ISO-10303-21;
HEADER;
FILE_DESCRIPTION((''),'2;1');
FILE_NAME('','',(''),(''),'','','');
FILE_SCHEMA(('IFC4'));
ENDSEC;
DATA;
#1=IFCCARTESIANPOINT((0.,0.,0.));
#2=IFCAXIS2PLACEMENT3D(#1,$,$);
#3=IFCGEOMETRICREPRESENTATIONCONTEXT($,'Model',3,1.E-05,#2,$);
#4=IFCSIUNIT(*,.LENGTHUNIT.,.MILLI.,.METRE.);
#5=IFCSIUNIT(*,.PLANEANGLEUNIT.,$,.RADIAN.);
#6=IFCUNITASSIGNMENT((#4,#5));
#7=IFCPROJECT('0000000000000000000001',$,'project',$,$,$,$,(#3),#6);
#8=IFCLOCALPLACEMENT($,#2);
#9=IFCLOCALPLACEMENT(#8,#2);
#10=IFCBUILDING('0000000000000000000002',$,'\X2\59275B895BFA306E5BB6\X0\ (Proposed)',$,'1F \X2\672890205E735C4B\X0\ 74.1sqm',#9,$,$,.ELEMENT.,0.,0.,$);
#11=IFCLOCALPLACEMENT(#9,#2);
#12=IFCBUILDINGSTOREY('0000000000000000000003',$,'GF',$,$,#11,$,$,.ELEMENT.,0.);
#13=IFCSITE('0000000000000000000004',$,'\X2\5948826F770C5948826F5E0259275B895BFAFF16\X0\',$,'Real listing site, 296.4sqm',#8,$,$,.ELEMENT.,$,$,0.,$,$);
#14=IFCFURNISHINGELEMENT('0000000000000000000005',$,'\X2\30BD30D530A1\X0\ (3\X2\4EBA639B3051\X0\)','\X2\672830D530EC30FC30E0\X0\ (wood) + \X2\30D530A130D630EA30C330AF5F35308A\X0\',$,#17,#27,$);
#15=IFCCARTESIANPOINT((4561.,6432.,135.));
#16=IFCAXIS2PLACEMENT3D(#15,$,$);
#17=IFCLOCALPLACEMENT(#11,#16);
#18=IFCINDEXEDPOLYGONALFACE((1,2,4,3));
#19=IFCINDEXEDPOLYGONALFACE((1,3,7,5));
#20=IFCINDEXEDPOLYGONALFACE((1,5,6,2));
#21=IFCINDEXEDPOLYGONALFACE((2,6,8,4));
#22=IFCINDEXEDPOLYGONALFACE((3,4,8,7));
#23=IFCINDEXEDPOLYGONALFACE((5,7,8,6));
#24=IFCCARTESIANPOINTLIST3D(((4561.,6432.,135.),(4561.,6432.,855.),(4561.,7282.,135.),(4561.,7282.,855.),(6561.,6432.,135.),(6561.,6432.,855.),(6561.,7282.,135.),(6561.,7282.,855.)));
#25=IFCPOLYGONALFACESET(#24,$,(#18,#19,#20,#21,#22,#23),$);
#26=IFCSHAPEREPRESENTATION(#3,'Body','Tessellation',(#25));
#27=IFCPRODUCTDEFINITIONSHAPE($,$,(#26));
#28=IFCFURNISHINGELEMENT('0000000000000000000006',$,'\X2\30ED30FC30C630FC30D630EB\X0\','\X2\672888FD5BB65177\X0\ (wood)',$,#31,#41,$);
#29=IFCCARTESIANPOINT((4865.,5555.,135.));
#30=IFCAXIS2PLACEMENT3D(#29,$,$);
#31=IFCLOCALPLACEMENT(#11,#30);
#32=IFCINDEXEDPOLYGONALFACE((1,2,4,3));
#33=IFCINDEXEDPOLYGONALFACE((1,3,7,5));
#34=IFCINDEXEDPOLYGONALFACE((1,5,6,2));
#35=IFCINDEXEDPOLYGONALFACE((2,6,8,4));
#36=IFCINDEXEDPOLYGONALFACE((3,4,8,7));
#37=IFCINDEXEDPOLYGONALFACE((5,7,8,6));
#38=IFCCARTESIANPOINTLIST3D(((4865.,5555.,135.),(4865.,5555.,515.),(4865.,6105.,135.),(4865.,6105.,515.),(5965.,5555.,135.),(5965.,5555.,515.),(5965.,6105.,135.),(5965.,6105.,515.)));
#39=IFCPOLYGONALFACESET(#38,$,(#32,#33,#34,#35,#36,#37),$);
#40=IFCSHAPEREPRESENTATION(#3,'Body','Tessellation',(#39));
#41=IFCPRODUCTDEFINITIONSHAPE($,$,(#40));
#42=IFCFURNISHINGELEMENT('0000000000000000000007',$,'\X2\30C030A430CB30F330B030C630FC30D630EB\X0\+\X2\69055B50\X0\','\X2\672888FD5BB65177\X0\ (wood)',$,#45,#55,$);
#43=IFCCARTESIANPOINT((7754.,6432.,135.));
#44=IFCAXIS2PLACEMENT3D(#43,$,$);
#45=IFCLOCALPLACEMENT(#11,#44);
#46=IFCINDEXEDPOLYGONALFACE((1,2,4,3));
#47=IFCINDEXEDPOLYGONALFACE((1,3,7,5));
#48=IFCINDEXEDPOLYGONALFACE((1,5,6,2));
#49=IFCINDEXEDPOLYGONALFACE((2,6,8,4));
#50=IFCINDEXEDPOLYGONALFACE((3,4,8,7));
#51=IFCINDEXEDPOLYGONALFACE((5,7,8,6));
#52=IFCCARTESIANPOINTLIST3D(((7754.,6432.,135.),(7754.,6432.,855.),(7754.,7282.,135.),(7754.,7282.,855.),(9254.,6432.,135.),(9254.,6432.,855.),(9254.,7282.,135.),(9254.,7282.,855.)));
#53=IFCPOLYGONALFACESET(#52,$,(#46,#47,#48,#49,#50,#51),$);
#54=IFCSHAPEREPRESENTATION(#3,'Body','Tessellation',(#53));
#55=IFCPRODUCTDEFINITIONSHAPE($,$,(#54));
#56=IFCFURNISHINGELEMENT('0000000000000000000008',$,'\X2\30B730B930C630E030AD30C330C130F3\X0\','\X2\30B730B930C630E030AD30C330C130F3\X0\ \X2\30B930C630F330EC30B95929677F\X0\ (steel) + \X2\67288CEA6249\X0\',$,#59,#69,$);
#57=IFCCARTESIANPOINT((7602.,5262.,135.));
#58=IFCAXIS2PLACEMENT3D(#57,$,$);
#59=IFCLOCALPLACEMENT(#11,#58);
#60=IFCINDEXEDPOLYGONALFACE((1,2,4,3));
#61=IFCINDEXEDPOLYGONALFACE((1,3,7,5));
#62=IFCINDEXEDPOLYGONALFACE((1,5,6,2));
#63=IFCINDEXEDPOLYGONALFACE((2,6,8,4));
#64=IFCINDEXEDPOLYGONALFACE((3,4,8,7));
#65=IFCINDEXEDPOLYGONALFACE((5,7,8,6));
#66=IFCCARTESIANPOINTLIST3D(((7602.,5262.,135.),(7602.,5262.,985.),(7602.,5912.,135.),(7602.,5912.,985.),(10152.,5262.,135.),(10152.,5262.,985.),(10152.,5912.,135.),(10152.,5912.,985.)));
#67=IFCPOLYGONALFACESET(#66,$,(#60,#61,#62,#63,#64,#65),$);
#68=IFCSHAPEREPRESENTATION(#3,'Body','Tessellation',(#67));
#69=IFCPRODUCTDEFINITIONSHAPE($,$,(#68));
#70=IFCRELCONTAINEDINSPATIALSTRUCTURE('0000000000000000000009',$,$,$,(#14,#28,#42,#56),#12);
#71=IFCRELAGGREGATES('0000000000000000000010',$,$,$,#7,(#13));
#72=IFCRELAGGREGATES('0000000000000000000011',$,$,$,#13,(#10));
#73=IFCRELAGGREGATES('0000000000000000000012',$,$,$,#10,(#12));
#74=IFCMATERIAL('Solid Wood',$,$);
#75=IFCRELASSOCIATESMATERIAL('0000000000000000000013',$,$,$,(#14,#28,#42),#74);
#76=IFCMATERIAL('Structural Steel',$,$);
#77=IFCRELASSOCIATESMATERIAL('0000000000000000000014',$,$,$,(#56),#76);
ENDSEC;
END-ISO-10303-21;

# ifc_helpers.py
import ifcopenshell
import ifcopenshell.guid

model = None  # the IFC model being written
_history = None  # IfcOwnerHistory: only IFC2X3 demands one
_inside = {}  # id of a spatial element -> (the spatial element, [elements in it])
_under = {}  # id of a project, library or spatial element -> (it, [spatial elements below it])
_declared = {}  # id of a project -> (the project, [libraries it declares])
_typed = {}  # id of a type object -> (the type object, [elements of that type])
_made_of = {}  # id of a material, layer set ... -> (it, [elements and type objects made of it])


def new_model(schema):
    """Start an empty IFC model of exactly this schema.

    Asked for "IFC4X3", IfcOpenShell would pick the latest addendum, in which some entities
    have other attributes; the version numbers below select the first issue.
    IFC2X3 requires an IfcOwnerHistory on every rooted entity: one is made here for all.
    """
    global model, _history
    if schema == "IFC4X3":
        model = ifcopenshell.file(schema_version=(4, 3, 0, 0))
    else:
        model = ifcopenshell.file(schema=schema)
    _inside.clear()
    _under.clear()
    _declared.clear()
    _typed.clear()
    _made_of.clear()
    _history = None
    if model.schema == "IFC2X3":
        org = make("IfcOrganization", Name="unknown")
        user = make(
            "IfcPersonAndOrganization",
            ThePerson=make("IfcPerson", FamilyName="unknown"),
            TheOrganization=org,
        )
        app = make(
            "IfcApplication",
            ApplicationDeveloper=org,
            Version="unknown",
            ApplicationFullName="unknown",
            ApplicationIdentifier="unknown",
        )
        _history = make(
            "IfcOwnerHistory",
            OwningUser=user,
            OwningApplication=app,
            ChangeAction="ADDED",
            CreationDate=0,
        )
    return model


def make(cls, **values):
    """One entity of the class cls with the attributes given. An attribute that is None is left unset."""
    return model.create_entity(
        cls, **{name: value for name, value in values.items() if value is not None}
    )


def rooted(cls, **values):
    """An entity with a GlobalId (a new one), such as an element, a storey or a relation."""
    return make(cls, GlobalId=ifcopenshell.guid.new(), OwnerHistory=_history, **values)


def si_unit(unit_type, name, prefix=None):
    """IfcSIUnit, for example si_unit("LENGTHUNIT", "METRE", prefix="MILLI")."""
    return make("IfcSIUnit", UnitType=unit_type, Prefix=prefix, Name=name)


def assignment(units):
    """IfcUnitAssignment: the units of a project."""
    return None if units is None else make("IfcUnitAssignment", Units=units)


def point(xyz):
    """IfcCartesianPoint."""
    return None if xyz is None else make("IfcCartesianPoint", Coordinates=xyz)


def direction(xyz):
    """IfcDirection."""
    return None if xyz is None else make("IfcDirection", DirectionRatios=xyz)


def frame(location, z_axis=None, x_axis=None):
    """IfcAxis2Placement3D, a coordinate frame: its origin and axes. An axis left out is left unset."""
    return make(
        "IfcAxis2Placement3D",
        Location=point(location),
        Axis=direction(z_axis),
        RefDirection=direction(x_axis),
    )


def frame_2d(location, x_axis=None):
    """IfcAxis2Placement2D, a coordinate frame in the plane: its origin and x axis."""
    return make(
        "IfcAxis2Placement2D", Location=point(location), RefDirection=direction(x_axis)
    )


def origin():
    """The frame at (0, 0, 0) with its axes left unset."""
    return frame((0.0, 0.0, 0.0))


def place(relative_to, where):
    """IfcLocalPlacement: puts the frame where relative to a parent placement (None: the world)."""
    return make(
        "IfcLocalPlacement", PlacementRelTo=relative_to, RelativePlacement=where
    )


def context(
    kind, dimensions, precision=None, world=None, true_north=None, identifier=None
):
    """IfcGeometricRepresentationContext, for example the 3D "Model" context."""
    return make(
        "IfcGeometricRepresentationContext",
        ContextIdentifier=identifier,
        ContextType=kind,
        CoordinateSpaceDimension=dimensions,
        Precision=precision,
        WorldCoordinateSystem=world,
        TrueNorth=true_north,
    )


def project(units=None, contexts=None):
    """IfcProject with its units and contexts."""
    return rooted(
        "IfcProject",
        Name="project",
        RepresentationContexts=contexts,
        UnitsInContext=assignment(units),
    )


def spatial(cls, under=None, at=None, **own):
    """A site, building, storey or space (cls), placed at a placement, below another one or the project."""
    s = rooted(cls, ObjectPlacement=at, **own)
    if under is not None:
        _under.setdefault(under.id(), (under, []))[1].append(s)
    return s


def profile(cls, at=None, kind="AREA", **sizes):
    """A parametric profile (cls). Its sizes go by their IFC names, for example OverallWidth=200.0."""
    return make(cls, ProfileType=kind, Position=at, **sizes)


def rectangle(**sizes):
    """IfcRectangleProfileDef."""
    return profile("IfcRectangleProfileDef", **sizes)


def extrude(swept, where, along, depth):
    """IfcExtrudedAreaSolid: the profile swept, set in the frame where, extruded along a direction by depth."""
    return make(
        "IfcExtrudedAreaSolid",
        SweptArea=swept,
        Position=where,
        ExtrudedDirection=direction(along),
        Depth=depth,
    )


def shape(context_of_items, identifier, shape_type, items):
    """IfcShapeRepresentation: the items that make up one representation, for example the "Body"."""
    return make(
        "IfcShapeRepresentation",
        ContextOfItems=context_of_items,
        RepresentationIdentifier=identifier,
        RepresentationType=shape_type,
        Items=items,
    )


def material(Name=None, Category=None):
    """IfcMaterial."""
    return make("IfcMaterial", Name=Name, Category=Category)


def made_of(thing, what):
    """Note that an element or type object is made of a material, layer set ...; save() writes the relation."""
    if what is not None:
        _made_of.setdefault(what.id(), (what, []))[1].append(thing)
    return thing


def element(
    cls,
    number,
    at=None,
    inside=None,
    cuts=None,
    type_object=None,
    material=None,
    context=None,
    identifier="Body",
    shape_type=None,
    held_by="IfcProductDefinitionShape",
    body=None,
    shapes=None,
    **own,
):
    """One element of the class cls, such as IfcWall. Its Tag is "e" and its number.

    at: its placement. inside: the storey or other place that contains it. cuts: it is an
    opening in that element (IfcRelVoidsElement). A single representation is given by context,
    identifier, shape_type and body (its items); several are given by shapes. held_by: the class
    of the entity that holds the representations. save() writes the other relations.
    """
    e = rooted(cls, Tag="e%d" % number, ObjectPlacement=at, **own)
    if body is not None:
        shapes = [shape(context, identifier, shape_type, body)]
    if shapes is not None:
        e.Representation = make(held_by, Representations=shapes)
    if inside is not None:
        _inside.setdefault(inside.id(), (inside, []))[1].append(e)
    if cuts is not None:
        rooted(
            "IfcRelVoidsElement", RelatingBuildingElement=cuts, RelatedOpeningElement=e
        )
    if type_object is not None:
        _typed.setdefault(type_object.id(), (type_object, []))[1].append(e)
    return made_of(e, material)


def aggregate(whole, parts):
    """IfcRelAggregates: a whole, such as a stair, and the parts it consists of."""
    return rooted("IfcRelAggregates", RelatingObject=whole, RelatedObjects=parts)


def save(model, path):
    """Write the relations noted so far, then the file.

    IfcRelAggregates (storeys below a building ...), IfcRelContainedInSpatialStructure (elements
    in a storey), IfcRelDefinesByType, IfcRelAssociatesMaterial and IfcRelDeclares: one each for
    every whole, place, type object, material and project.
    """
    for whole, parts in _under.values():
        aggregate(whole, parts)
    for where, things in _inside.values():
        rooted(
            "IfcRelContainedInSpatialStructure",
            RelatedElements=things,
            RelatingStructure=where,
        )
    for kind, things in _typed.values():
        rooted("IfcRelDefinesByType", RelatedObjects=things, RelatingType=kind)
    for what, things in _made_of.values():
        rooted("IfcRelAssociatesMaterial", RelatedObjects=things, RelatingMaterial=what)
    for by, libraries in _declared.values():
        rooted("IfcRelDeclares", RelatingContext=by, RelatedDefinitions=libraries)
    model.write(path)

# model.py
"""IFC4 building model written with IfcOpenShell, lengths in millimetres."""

from ifc_helpers import new_model, si_unit, frame, frame_2d, origin, place, context, project, spatial, rectangle, extrude, material, element, save


model = new_model("IFC4")

# Units and contexts
model_context = context("Model", 3, precision=1e-05, world=origin())
ifc_project = project(units=[si_unit("LENGTHUNIT", "METRE", prefix="MILLI"), si_unit("PLANEANGLEUNIT", "RADIAN")], contexts=[model_context])

# Site, building, storey
site_placement = place(None, origin())
site = spatial("IfcSite", under=ifc_project, at=site_placement, Name="奈良県奈良市大安寺６", ObjectType="Real listing site, 296.4sqm", CompositionType="ELEMENT", RefElevation=0.0)
building_placement = place(site_placement, origin())
building = spatial("IfcBuilding", under=site, at=building_placement, Name="大安寺の家 (Proposed)", ObjectType="1F 木造平屋 74.1sqm", CompositionType="ELEMENT", ElevationOfRefHeight=0.0, ElevationOfTerrain=0.0)
storey_placement = place(building_placement, origin())
storey = spatial("IfcBuildingStorey", under=building, at=storey_placement, Name="GF", CompositionType="ELEMENT", Elevation=0.0)

# Shared definitions
ifc_material_1 = material(Name="Solid Wood")

# Shared definitions
ifc_material_2 = material(Name="Structural Steel")

# Furnishing elements
furnishing_1_placement = place(storey_placement, frame((4561.0, 6432.0, 135.0)))
element("IfcFurnishingElement", 1, at=furnishing_1_placement, inside=storey, material=ifc_material_1, Name="ソファ (3人掛け)", Description="木フレーム (wood) + ファブリック張り", context=model_context, shape_type="SweptSolid", body=[
    extrude(rectangle(XDim=2000.0, YDim=850.0, at=frame_2d((1000.0, 425.0))), frame((4561.0, 6432.0, 135.0)), (0.0, 0.0, 1.0), 720.0),
])
furnishing_2_placement = place(storey_placement, frame((4865.0, 5555.0, 135.0)))
element("IfcFurnishingElement", 2, at=furnishing_2_placement, inside=storey, material=ifc_material_1, Name="ローテーブル", Description="木製家具 (wood)", context=model_context, shape_type="SweptSolid", body=[
    extrude(rectangle(XDim=1100.0, YDim=550.0, at=frame_2d((550.0, 275.0))), frame((4865.0, 5555.0, 135.0)), (0.0, 0.0, 1.0), 380.0),
])
furnishing_3_placement = place(storey_placement, frame((7754.0, 6432.0, 135.0)))
element("IfcFurnishingElement", 3, at=furnishing_3_placement, inside=storey, material=ifc_material_1, Name="ダイニングテーブル+椅子", Description="木製家具 (wood)", context=model_context, shape_type="SweptSolid", body=[
    extrude(rectangle(XDim=1500.0, YDim=850.0, at=frame_2d((750.0, 425.0))), frame((7754.0, 6432.0, 135.0)), (0.0, 0.0, 1.0), 720.0),
])
furnishing_4_placement = place(storey_placement, frame((7602.0, 5262.0, 135.0)))
element("IfcFurnishingElement", 4, at=furnishing_4_placement, inside=storey, material=ifc_material_2, Name="システムキッチン", Description="システムキッチン ステンレス天板 (steel) + 木質扉", context=model_context, shape_type="SweptSolid", body=[
    extrude(rectangle(XDim=2550.0, YDim=650.0, at=frame_2d((1275.0, 325.0))), frame((7602.0, 5262.0, 135.0)), (0.0, 0.0, 1.0), 850.0),
])

save(model, "model.ifc")
